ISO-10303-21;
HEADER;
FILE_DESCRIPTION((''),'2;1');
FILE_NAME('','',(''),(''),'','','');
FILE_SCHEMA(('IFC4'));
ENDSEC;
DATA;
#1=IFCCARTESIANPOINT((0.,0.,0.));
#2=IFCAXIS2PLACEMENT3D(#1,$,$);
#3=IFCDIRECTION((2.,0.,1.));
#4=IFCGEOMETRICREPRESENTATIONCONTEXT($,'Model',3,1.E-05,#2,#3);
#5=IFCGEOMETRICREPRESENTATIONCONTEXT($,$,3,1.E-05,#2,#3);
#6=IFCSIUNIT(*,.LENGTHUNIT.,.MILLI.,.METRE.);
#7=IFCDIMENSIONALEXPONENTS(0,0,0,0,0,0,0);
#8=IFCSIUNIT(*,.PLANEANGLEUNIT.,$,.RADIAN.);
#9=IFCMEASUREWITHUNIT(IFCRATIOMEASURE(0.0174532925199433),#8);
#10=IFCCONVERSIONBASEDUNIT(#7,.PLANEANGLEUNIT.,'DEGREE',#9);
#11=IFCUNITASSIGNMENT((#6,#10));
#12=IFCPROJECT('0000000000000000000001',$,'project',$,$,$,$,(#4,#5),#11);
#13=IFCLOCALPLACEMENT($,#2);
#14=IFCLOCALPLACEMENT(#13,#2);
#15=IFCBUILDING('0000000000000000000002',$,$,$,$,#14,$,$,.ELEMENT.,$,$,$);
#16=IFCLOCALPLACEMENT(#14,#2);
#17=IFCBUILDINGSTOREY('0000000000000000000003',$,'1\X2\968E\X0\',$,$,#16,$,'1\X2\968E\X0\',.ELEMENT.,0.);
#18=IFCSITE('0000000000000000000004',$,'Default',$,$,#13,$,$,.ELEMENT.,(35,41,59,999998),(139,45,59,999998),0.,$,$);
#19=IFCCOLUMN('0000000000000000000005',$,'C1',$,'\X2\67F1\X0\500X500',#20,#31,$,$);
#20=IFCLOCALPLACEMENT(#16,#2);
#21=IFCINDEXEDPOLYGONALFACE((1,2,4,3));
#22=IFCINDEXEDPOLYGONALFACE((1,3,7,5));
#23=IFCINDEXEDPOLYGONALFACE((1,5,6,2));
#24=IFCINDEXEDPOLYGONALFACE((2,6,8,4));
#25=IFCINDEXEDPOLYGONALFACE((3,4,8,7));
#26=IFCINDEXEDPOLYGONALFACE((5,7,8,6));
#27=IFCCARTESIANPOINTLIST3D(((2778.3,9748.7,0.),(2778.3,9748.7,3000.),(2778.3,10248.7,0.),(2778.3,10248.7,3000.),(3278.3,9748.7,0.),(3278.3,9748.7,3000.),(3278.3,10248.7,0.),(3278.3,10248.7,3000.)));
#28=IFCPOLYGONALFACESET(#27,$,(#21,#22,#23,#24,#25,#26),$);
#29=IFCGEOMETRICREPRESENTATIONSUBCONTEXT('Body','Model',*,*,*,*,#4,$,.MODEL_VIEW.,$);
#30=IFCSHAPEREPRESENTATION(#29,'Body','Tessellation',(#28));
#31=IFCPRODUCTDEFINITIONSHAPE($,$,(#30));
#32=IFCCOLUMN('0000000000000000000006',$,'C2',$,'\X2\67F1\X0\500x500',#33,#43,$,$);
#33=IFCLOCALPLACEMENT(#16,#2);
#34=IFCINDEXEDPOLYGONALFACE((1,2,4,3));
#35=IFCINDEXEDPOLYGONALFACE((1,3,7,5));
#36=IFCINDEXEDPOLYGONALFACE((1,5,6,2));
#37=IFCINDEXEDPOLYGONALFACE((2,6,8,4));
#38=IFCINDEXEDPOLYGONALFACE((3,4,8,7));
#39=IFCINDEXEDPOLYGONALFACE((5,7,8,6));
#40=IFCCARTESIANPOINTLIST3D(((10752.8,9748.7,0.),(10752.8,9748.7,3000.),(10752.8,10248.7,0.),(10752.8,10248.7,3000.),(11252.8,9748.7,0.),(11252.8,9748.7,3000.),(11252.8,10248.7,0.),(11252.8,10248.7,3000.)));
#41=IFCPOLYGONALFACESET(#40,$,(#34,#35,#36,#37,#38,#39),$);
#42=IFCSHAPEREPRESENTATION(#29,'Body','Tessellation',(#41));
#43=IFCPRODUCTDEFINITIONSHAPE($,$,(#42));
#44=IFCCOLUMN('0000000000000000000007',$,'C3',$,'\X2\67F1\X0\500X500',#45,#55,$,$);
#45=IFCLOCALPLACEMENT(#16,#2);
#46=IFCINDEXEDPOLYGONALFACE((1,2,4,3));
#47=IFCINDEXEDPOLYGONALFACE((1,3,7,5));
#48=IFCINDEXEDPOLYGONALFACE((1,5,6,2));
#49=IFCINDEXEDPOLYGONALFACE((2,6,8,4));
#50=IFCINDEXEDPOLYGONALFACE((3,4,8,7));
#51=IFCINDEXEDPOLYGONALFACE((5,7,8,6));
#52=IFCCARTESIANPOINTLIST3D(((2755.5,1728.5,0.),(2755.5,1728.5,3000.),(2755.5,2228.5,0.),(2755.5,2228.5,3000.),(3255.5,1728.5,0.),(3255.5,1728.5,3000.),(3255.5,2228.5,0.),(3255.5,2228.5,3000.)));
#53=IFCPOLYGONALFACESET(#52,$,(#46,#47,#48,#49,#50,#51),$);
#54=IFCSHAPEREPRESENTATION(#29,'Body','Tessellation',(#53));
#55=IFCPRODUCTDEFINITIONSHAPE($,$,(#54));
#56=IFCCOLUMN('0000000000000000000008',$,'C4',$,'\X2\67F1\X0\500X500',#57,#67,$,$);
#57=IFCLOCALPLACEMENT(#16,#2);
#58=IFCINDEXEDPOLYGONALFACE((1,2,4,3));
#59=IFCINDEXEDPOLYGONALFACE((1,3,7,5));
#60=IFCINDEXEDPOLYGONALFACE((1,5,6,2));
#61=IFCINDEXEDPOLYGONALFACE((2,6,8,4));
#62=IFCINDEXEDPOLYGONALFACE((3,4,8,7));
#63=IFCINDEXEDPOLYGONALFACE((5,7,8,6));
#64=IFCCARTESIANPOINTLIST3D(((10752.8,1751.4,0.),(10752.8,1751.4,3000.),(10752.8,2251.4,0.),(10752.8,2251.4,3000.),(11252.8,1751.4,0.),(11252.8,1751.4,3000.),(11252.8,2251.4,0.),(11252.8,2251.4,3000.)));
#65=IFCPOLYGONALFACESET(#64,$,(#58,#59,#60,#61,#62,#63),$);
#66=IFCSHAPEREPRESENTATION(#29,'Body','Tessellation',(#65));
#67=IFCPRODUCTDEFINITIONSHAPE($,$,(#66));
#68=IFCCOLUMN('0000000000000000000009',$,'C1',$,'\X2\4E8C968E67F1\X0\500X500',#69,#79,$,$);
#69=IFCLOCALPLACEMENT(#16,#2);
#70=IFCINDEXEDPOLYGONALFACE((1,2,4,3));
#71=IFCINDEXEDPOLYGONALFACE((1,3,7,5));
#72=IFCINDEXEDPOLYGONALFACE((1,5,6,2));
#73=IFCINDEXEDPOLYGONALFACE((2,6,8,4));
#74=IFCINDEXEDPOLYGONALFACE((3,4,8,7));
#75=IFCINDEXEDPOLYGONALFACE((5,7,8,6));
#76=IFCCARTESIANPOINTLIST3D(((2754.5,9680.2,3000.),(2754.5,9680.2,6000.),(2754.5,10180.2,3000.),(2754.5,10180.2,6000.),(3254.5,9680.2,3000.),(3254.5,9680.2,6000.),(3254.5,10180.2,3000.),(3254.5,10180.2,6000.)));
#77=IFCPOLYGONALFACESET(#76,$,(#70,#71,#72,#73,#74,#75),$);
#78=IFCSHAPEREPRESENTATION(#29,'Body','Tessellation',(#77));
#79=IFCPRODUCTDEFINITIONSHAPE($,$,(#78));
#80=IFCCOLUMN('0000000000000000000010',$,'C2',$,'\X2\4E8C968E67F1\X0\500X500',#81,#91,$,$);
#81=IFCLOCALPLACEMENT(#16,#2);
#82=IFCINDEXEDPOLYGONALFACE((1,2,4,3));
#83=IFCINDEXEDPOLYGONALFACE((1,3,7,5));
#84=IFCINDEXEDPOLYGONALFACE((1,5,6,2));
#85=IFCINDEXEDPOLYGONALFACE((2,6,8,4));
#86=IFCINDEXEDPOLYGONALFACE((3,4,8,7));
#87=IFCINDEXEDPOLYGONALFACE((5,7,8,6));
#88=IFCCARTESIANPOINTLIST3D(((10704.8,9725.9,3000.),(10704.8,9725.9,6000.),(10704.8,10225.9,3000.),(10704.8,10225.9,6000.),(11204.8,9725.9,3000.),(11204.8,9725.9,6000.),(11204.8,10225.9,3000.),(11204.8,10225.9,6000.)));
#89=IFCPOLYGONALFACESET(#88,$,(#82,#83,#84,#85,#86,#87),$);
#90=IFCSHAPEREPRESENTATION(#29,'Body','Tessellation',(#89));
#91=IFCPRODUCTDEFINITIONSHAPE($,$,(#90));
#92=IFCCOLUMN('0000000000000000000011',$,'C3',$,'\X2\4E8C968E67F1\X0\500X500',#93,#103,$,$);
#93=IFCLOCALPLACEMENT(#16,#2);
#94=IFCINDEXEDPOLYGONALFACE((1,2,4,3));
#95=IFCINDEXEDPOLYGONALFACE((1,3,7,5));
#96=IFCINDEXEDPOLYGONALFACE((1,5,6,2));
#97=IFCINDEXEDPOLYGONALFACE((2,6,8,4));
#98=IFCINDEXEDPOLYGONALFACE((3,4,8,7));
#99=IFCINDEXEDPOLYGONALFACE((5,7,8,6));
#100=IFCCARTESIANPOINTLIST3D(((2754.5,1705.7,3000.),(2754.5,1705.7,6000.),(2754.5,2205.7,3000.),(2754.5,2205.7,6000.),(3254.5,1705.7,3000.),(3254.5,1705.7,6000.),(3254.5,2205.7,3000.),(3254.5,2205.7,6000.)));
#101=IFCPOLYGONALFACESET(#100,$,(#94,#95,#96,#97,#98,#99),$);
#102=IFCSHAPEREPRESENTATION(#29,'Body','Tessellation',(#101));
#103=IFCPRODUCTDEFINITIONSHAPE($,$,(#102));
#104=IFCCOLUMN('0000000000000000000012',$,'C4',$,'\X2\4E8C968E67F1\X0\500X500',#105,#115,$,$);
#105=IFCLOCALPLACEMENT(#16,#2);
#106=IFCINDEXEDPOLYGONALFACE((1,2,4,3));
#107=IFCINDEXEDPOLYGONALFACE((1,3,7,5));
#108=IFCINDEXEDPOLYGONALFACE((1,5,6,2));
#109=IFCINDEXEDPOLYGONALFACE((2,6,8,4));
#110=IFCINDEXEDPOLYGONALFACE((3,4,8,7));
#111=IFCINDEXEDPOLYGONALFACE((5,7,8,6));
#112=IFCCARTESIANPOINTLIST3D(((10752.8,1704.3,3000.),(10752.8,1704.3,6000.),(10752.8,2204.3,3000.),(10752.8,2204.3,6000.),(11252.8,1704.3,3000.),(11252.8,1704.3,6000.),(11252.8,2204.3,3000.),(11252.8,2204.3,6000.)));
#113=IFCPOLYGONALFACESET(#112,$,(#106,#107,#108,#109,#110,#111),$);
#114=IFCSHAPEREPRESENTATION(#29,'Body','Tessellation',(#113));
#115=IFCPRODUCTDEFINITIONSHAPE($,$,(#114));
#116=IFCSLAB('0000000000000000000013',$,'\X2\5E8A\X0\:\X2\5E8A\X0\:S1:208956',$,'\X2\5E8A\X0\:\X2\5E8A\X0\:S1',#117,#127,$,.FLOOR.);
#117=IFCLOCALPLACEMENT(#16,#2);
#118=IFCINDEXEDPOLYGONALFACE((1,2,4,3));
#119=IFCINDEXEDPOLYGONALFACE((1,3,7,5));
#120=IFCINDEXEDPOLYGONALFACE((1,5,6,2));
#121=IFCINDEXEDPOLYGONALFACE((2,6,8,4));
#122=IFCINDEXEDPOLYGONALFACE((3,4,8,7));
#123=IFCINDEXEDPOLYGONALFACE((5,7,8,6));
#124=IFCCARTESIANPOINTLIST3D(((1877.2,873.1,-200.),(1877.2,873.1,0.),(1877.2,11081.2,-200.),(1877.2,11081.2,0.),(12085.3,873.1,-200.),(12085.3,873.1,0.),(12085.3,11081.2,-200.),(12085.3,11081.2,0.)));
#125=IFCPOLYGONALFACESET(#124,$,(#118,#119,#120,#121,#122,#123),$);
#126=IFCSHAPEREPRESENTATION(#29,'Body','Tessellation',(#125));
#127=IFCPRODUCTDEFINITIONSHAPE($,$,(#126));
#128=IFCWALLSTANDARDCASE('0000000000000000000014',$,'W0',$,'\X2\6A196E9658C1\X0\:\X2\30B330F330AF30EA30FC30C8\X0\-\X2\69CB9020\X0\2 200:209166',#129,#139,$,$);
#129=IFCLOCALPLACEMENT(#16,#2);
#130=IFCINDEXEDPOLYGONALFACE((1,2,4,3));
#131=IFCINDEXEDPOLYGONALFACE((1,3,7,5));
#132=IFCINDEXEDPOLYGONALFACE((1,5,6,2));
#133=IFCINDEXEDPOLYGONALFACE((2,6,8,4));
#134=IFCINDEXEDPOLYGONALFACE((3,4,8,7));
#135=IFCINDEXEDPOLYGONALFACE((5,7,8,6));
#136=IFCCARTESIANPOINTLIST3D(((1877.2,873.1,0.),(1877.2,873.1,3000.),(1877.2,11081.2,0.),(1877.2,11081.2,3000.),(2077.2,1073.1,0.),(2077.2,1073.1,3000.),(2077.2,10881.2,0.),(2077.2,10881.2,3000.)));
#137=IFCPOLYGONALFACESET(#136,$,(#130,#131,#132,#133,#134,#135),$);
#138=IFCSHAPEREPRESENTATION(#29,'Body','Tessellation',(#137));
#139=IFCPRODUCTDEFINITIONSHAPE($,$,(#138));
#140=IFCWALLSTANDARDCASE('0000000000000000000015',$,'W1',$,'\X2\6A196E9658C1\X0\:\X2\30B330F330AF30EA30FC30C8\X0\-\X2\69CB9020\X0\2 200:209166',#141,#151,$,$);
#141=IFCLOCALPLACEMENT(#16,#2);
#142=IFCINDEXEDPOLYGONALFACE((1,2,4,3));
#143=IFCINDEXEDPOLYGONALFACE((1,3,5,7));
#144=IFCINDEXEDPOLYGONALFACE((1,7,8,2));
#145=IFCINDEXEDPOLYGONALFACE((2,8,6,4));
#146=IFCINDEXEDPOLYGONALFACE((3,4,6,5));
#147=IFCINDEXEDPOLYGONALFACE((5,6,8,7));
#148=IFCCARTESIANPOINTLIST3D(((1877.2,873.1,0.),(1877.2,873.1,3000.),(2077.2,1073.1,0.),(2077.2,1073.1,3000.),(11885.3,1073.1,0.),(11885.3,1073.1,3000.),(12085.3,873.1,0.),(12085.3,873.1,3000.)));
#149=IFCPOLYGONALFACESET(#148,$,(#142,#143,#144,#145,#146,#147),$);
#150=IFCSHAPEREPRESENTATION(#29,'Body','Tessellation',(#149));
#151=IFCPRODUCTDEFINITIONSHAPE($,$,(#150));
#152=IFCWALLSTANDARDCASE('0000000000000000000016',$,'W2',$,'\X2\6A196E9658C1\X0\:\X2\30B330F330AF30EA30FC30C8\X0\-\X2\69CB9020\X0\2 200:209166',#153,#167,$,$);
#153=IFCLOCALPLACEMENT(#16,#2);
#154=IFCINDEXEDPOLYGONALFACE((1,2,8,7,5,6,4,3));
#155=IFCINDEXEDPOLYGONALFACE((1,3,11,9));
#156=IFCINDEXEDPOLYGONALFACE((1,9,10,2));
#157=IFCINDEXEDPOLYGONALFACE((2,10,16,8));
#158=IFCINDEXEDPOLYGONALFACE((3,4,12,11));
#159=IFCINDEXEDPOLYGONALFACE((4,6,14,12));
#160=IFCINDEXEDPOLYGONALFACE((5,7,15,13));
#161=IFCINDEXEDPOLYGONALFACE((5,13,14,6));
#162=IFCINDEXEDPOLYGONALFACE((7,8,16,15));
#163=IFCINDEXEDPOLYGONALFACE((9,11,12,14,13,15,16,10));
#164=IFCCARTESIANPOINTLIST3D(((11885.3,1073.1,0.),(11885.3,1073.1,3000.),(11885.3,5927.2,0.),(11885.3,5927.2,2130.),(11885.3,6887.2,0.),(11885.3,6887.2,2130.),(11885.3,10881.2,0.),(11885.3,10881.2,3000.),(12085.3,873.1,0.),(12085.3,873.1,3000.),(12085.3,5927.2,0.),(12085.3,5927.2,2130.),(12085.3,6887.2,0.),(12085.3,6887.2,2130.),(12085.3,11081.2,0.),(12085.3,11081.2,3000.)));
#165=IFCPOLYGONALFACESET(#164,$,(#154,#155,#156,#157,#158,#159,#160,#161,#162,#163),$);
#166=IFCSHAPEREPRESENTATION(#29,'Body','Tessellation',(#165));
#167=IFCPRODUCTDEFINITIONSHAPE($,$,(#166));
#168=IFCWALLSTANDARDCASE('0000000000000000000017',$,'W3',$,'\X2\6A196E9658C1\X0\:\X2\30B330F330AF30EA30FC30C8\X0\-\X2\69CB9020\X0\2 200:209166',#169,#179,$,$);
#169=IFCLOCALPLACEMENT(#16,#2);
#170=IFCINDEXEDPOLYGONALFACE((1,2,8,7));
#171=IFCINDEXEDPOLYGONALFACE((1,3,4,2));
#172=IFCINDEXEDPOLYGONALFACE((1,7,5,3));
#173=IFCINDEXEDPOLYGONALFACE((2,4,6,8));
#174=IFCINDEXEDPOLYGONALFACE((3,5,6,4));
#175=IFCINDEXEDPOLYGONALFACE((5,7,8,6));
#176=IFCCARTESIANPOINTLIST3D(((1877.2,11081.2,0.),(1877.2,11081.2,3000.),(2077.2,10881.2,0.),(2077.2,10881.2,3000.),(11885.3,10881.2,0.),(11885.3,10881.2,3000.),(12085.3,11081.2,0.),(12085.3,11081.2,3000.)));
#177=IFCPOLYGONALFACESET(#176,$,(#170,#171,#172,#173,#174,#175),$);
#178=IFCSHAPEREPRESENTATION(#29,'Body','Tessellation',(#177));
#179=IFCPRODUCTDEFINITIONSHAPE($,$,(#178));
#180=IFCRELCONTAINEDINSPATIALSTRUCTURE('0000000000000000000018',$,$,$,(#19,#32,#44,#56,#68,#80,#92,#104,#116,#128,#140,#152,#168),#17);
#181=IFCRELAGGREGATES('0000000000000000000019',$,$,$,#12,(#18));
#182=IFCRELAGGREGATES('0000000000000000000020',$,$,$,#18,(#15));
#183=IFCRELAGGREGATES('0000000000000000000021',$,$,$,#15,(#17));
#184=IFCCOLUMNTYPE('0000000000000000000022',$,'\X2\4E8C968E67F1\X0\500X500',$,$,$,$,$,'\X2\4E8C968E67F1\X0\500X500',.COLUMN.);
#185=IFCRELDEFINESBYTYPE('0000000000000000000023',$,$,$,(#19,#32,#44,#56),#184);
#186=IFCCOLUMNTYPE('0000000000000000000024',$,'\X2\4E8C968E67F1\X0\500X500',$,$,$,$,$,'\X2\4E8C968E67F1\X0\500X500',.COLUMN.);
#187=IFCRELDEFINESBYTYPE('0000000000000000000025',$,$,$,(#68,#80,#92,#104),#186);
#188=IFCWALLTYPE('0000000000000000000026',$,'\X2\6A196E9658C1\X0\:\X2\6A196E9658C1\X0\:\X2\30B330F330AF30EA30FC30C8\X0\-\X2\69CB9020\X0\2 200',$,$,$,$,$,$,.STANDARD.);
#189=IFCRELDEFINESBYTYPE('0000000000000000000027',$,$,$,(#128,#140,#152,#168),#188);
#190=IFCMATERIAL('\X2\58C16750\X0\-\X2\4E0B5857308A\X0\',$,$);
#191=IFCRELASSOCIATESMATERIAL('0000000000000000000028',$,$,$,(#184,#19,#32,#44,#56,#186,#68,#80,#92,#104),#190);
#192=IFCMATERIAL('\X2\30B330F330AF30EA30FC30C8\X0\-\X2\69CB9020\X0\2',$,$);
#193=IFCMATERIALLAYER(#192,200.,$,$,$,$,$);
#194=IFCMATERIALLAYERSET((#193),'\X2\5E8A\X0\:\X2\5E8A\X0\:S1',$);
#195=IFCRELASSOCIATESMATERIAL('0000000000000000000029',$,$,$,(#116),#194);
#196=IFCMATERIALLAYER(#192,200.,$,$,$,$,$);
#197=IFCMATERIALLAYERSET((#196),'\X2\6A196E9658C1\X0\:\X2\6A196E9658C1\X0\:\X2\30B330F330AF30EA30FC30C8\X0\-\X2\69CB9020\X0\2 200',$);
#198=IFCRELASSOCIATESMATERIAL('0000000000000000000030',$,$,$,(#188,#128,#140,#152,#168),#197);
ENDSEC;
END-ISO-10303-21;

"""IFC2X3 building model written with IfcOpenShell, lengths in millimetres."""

from ifc_helpers import new_model, entity, si_unit, converted_unit, direction, frame, frame_2d, origin, origin_2d_with_axis, place, context, subcontext, project, spatial, polyline, rectangle, outline, extrude, source, transform, mapped, material, layer, layer_set, layer_usage, type_object, type_shapes, element, save


model = new_model("IFC2X3")

# Units and contexts
model_context = context("Model", 3, precision=1e-05, world=origin(), true_north=direction((2.0, 0.0, 1.0)))
context_of_model = context(None, 3, precision=1e-05, world=origin(), true_north=direction((2.0, 0.0, 1.0)))
body_context = subcontext(model_context, "Body", "Model", "MODEL_VIEW")
ifc_project = project(units=[si_unit("LENGTHUNIT", "METRE", prefix="MILLI"), converted_unit("PLANEANGLEUNIT", "DEGREE", entity("IfcRatioMeasure", 0.0174532925199433), si_unit("PLANEANGLEUNIT", "RADIAN"), dimensions=[0, 0, 0, 0, 0, 0, 0])], contexts=[model_context, context_of_model])

# Site, building, storey
site_placement = place(None, origin())
site = spatial("IfcSite", under=ifc_project, at=site_placement, Name="Default", CompositionType="ELEMENT", RefLatitude=(35, 41, 59, 999998), RefLongitude=(139, 45, 59, 999998), RefElevation=0.0)
building_placement = place(site_placement, origin())
building = spatial("IfcBuilding", under=site, at=building_placement, CompositionType="ELEMENT")
storey_placement = place(building_placement, origin())
storey = spatial("IfcBuildingStorey", under=building, at=storey_placement, Name="1階", LongName="1階", CompositionType="ELEMENT", Elevation=0.0)

# Columns
ifc_material_1 = material(Name="壁材-下塗り")
column_type_1 = type_object("IfcColumnType", Name="二階柱500X500", ElementType="二階柱500X500", PredefinedType="COLUMN", material=ifc_material_1)
shared_shape_1 = source(origin(), body_context, "Body", "SweptSolid", [
    extrude(rectangle(XDim=500.0, YDim=500.0, at=origin_2d_with_axis()), origin(), (0.0, 0.0, 1.0), 3000.0),
])
type_shapes(column_type_1, [shared_shape_1])
column_1_placement = place(storey_placement, frame((3028.3, 9998.7, 0.0)))
element("IfcColumn", 1, at=column_1_placement, inside=storey, type_object=column_type_1, material=ifc_material_1, Name="C1", ObjectType="柱500X500", context=body_context, shape_type="MappedRepresentation", body=[
    mapped(shared_shape_1, transform((0.0, 0.0, 0.0), scale=1.0)),
])
column_2_placement = place(storey_placement, frame((11002.8, 9998.7, 0.0)))
element("IfcColumn", 2, at=column_2_placement, inside=storey, type_object=column_type_1, material=ifc_material_1, Name="C2", ObjectType="柱500x500", context=body_context, shape_type="MappedRepresentation", body=[
    mapped(shared_shape_1, transform((0.0, 0.0, 0.0), scale=1.0)),
])
for number, where, name in (
    (3, (3005.5, 1978.5, 0.0), "C3"),
    (4, (11002.8, 2001.4, 0.0), "C4"),
):
    element("IfcColumn", number, at=place(storey_placement, frame(where)), inside=storey, type_object=column_type_1, material=ifc_material_1, Name=name, ObjectType="柱500X500", context=body_context, shape_type="MappedRepresentation", body=[
        mapped(shared_shape_1, transform((0.0, 0.0, 0.0), scale=1.0)),
    ])
column_type_2 = type_object("IfcColumnType", Name="二階柱500X500", ElementType="二階柱500X500", PredefinedType="COLUMN", material=ifc_material_1)
shared_shape_2 = source(origin(), body_context, "Body", "SweptSolid", [
    extrude(rectangle(XDim=500.0, YDim=500.0, at=origin_2d_with_axis()), origin(), (0.0, 0.0, 1.0), 3000.0),
])
type_shapes(column_type_2, [shared_shape_2])
for number, where, name in (
    (5, (3004.5, 9930.2, 3000.0), "C1"),
    (6, (10954.8, 9975.9, 3000.0), "C2"),
    (7, (3004.5, 1955.7, 3000.0), "C3"),
    (8, (11002.8, 1954.3, 3000.0), "C4"),
):
    element("IfcColumn", number, at=place(storey_placement, frame(where)), inside=storey, type_object=column_type_2, material=ifc_material_1, Name=name, ObjectType="二階柱500X500", context=body_context, shape_type="MappedRepresentation", body=[
        mapped(shared_shape_2, transform((0.0, 0.0, 0.0), scale=1.0)),
    ])

# Slab
ifc_material_2 = material(Name="コンクリート-構造2")
ifc_layer_1 = layer(ifc_material_2, 200.0)
ifc_layer_set_1 = layer_set([ifc_layer_1], Name="床:床:S1")
ifc_layer_usage_1 = layer_usage(ifc_layer_set_1, "AXIS3", "POSITIVE", 0.0)
slab_placement = place(storey_placement, origin())
element("IfcSlab", 9, at=slab_placement, inside=storey, material=ifc_layer_usage_1, Name="床:床:S1:208956", ObjectType="床:床:S1", PredefinedType="FLOOR", context=body_context, shape_type="SweptSolid", body=[
    extrude(rectangle(XDim=10208.1, YDim=10208.1, at=origin_2d_with_axis()), frame((6981.3, 5977.2, 0.0), z_axis=(0.0, 0.0, -1.0), x_axis=(0.0, 1.0, 0.0)), (0.0, 0.0, 1.0), 200.0),
])

# Walls
ifc_layer_2 = layer(ifc_material_2, 200.0)
ifc_layer_set_2 = layer_set([ifc_layer_2], Name="標準壁:標準壁:コンクリート-構造2 200")
ifc_layer_usage_2 = layer_usage(ifc_layer_set_2, "AXIS2", "NEGATIVE", 100.0)
wall_type = type_object("IfcWallType", Name="標準壁:標準壁:コンクリート-構造2 200", PredefinedType="STANDARD", material=ifc_layer_set_2)
wall_1_placement = place(storey_placement, frame((1977.2, 11081.2, 0.0), z_axis=(0.0, 0.0, 1.0), x_axis=(0.0, -1.0, 0.0)))
element("IfcWallStandardCase", 10, at=wall_1_placement, inside=storey, type_object=wall_type, material=ifc_layer_usage_2, Name="W0", ObjectType="標準壁:コンクリート-構造2 200:209166", context=body_context, shape_type="SweptSolid", body=[
    extrude(outline(polyline([(10208.1, -100.0), (10008.1, 100.0), (200.0, 100.0), (0.0, -100.0), (10208.1, -100.0)])), origin(), (0.0, 0.0, 1.0), 3000.0),
])
ifc_layer_usage_3 = layer_usage(ifc_layer_set_2, "AXIS2", "NEGATIVE", 100.0)
wall_2_placement = place(storey_placement, frame((1877.2, 973.1, 0.0)))
element("IfcWallStandardCase", 11, at=wall_2_placement, inside=storey, type_object=wall_type, material=ifc_layer_usage_3, Name="W1", ObjectType="標準壁:コンクリート-構造2 200:209166", context=body_context, shape_type="SweptSolid", body=[
    extrude(outline(polyline([(10208.1, -100.0), (10008.1, 100.0), (200.0, 100.0), (0.0, -100.0), (10208.1, -100.0)])), origin(), (0.0, 0.0, 1.0), 3000.0),
])

# Wall, opening
ifc_layer_usage_4 = layer_usage(ifc_layer_set_2, "AXIS2", "NEGATIVE", 100.0)
wall_3_placement = place(storey_placement, frame((11985.3, 873.1, 0.0), z_axis=(0.0, 0.0, 1.0), x_axis=(0.0, 1.0, 0.0)))
wall_3 = element("IfcWallStandardCase", 12, at=wall_3_placement, inside=storey, type_object=wall_type, material=ifc_layer_usage_4, Name="W2", ObjectType="標準壁:コンクリート-構造2 200:209166", context=body_context, shape_type="SweptSolid", body=[
    extrude(outline(polyline([(0.0, -100.0), (10208.1, -100.0), (10008.1, 100.0), (200.0, 100.0), (0.0, -100.0)])), origin(), (0.0, 0.0, 1.0), 3000.0),
])
opening_placement = place(wall_3_placement, origin())
element("IfcOpeningElement", 13, at=opening_placement, cuts=wall_3, ObjectType="Opening", context=body_context, shape_type="SweptSolid", body=[
    extrude(rectangle(XDim=2130.0, YDim=960.0, at=frame_2d((0.0, 0.0), x_axis=(0.0, 1.0))), frame((5534.1, -208.1, 1065.0), z_axis=(0.0, 1.0, 0.0), x_axis=(-1.0, 0.0, 0.0)), (0.0, 0.0, 1.0), 416.2),
])

# Wall
ifc_layer_usage_5 = layer_usage(ifc_layer_set_2, "AXIS2", "NEGATIVE", 100.0)
wall_4_placement = place(storey_placement, frame((12085.3, 10981.2, 0.0), z_axis=(0.0, 0.0, 1.0), x_axis=(-1.0, 0.0, 0.0)))
element("IfcWallStandardCase", 14, at=wall_4_placement, inside=storey, type_object=wall_type, material=ifc_layer_usage_5, Name="W3", ObjectType="標準壁:コンクリート-構造2 200:209166", context=body_context, shape_type="SweptSolid", body=[
    extrude(outline(polyline([(10208.1, -100.0), (10008.1, 100.0), (200.0, 100.0), (0.0, -100.0), (10208.1, -100.0)])), origin(), (0.0, 0.0, 1.0), 3000.0),
])

save(model, "model.ifc")
